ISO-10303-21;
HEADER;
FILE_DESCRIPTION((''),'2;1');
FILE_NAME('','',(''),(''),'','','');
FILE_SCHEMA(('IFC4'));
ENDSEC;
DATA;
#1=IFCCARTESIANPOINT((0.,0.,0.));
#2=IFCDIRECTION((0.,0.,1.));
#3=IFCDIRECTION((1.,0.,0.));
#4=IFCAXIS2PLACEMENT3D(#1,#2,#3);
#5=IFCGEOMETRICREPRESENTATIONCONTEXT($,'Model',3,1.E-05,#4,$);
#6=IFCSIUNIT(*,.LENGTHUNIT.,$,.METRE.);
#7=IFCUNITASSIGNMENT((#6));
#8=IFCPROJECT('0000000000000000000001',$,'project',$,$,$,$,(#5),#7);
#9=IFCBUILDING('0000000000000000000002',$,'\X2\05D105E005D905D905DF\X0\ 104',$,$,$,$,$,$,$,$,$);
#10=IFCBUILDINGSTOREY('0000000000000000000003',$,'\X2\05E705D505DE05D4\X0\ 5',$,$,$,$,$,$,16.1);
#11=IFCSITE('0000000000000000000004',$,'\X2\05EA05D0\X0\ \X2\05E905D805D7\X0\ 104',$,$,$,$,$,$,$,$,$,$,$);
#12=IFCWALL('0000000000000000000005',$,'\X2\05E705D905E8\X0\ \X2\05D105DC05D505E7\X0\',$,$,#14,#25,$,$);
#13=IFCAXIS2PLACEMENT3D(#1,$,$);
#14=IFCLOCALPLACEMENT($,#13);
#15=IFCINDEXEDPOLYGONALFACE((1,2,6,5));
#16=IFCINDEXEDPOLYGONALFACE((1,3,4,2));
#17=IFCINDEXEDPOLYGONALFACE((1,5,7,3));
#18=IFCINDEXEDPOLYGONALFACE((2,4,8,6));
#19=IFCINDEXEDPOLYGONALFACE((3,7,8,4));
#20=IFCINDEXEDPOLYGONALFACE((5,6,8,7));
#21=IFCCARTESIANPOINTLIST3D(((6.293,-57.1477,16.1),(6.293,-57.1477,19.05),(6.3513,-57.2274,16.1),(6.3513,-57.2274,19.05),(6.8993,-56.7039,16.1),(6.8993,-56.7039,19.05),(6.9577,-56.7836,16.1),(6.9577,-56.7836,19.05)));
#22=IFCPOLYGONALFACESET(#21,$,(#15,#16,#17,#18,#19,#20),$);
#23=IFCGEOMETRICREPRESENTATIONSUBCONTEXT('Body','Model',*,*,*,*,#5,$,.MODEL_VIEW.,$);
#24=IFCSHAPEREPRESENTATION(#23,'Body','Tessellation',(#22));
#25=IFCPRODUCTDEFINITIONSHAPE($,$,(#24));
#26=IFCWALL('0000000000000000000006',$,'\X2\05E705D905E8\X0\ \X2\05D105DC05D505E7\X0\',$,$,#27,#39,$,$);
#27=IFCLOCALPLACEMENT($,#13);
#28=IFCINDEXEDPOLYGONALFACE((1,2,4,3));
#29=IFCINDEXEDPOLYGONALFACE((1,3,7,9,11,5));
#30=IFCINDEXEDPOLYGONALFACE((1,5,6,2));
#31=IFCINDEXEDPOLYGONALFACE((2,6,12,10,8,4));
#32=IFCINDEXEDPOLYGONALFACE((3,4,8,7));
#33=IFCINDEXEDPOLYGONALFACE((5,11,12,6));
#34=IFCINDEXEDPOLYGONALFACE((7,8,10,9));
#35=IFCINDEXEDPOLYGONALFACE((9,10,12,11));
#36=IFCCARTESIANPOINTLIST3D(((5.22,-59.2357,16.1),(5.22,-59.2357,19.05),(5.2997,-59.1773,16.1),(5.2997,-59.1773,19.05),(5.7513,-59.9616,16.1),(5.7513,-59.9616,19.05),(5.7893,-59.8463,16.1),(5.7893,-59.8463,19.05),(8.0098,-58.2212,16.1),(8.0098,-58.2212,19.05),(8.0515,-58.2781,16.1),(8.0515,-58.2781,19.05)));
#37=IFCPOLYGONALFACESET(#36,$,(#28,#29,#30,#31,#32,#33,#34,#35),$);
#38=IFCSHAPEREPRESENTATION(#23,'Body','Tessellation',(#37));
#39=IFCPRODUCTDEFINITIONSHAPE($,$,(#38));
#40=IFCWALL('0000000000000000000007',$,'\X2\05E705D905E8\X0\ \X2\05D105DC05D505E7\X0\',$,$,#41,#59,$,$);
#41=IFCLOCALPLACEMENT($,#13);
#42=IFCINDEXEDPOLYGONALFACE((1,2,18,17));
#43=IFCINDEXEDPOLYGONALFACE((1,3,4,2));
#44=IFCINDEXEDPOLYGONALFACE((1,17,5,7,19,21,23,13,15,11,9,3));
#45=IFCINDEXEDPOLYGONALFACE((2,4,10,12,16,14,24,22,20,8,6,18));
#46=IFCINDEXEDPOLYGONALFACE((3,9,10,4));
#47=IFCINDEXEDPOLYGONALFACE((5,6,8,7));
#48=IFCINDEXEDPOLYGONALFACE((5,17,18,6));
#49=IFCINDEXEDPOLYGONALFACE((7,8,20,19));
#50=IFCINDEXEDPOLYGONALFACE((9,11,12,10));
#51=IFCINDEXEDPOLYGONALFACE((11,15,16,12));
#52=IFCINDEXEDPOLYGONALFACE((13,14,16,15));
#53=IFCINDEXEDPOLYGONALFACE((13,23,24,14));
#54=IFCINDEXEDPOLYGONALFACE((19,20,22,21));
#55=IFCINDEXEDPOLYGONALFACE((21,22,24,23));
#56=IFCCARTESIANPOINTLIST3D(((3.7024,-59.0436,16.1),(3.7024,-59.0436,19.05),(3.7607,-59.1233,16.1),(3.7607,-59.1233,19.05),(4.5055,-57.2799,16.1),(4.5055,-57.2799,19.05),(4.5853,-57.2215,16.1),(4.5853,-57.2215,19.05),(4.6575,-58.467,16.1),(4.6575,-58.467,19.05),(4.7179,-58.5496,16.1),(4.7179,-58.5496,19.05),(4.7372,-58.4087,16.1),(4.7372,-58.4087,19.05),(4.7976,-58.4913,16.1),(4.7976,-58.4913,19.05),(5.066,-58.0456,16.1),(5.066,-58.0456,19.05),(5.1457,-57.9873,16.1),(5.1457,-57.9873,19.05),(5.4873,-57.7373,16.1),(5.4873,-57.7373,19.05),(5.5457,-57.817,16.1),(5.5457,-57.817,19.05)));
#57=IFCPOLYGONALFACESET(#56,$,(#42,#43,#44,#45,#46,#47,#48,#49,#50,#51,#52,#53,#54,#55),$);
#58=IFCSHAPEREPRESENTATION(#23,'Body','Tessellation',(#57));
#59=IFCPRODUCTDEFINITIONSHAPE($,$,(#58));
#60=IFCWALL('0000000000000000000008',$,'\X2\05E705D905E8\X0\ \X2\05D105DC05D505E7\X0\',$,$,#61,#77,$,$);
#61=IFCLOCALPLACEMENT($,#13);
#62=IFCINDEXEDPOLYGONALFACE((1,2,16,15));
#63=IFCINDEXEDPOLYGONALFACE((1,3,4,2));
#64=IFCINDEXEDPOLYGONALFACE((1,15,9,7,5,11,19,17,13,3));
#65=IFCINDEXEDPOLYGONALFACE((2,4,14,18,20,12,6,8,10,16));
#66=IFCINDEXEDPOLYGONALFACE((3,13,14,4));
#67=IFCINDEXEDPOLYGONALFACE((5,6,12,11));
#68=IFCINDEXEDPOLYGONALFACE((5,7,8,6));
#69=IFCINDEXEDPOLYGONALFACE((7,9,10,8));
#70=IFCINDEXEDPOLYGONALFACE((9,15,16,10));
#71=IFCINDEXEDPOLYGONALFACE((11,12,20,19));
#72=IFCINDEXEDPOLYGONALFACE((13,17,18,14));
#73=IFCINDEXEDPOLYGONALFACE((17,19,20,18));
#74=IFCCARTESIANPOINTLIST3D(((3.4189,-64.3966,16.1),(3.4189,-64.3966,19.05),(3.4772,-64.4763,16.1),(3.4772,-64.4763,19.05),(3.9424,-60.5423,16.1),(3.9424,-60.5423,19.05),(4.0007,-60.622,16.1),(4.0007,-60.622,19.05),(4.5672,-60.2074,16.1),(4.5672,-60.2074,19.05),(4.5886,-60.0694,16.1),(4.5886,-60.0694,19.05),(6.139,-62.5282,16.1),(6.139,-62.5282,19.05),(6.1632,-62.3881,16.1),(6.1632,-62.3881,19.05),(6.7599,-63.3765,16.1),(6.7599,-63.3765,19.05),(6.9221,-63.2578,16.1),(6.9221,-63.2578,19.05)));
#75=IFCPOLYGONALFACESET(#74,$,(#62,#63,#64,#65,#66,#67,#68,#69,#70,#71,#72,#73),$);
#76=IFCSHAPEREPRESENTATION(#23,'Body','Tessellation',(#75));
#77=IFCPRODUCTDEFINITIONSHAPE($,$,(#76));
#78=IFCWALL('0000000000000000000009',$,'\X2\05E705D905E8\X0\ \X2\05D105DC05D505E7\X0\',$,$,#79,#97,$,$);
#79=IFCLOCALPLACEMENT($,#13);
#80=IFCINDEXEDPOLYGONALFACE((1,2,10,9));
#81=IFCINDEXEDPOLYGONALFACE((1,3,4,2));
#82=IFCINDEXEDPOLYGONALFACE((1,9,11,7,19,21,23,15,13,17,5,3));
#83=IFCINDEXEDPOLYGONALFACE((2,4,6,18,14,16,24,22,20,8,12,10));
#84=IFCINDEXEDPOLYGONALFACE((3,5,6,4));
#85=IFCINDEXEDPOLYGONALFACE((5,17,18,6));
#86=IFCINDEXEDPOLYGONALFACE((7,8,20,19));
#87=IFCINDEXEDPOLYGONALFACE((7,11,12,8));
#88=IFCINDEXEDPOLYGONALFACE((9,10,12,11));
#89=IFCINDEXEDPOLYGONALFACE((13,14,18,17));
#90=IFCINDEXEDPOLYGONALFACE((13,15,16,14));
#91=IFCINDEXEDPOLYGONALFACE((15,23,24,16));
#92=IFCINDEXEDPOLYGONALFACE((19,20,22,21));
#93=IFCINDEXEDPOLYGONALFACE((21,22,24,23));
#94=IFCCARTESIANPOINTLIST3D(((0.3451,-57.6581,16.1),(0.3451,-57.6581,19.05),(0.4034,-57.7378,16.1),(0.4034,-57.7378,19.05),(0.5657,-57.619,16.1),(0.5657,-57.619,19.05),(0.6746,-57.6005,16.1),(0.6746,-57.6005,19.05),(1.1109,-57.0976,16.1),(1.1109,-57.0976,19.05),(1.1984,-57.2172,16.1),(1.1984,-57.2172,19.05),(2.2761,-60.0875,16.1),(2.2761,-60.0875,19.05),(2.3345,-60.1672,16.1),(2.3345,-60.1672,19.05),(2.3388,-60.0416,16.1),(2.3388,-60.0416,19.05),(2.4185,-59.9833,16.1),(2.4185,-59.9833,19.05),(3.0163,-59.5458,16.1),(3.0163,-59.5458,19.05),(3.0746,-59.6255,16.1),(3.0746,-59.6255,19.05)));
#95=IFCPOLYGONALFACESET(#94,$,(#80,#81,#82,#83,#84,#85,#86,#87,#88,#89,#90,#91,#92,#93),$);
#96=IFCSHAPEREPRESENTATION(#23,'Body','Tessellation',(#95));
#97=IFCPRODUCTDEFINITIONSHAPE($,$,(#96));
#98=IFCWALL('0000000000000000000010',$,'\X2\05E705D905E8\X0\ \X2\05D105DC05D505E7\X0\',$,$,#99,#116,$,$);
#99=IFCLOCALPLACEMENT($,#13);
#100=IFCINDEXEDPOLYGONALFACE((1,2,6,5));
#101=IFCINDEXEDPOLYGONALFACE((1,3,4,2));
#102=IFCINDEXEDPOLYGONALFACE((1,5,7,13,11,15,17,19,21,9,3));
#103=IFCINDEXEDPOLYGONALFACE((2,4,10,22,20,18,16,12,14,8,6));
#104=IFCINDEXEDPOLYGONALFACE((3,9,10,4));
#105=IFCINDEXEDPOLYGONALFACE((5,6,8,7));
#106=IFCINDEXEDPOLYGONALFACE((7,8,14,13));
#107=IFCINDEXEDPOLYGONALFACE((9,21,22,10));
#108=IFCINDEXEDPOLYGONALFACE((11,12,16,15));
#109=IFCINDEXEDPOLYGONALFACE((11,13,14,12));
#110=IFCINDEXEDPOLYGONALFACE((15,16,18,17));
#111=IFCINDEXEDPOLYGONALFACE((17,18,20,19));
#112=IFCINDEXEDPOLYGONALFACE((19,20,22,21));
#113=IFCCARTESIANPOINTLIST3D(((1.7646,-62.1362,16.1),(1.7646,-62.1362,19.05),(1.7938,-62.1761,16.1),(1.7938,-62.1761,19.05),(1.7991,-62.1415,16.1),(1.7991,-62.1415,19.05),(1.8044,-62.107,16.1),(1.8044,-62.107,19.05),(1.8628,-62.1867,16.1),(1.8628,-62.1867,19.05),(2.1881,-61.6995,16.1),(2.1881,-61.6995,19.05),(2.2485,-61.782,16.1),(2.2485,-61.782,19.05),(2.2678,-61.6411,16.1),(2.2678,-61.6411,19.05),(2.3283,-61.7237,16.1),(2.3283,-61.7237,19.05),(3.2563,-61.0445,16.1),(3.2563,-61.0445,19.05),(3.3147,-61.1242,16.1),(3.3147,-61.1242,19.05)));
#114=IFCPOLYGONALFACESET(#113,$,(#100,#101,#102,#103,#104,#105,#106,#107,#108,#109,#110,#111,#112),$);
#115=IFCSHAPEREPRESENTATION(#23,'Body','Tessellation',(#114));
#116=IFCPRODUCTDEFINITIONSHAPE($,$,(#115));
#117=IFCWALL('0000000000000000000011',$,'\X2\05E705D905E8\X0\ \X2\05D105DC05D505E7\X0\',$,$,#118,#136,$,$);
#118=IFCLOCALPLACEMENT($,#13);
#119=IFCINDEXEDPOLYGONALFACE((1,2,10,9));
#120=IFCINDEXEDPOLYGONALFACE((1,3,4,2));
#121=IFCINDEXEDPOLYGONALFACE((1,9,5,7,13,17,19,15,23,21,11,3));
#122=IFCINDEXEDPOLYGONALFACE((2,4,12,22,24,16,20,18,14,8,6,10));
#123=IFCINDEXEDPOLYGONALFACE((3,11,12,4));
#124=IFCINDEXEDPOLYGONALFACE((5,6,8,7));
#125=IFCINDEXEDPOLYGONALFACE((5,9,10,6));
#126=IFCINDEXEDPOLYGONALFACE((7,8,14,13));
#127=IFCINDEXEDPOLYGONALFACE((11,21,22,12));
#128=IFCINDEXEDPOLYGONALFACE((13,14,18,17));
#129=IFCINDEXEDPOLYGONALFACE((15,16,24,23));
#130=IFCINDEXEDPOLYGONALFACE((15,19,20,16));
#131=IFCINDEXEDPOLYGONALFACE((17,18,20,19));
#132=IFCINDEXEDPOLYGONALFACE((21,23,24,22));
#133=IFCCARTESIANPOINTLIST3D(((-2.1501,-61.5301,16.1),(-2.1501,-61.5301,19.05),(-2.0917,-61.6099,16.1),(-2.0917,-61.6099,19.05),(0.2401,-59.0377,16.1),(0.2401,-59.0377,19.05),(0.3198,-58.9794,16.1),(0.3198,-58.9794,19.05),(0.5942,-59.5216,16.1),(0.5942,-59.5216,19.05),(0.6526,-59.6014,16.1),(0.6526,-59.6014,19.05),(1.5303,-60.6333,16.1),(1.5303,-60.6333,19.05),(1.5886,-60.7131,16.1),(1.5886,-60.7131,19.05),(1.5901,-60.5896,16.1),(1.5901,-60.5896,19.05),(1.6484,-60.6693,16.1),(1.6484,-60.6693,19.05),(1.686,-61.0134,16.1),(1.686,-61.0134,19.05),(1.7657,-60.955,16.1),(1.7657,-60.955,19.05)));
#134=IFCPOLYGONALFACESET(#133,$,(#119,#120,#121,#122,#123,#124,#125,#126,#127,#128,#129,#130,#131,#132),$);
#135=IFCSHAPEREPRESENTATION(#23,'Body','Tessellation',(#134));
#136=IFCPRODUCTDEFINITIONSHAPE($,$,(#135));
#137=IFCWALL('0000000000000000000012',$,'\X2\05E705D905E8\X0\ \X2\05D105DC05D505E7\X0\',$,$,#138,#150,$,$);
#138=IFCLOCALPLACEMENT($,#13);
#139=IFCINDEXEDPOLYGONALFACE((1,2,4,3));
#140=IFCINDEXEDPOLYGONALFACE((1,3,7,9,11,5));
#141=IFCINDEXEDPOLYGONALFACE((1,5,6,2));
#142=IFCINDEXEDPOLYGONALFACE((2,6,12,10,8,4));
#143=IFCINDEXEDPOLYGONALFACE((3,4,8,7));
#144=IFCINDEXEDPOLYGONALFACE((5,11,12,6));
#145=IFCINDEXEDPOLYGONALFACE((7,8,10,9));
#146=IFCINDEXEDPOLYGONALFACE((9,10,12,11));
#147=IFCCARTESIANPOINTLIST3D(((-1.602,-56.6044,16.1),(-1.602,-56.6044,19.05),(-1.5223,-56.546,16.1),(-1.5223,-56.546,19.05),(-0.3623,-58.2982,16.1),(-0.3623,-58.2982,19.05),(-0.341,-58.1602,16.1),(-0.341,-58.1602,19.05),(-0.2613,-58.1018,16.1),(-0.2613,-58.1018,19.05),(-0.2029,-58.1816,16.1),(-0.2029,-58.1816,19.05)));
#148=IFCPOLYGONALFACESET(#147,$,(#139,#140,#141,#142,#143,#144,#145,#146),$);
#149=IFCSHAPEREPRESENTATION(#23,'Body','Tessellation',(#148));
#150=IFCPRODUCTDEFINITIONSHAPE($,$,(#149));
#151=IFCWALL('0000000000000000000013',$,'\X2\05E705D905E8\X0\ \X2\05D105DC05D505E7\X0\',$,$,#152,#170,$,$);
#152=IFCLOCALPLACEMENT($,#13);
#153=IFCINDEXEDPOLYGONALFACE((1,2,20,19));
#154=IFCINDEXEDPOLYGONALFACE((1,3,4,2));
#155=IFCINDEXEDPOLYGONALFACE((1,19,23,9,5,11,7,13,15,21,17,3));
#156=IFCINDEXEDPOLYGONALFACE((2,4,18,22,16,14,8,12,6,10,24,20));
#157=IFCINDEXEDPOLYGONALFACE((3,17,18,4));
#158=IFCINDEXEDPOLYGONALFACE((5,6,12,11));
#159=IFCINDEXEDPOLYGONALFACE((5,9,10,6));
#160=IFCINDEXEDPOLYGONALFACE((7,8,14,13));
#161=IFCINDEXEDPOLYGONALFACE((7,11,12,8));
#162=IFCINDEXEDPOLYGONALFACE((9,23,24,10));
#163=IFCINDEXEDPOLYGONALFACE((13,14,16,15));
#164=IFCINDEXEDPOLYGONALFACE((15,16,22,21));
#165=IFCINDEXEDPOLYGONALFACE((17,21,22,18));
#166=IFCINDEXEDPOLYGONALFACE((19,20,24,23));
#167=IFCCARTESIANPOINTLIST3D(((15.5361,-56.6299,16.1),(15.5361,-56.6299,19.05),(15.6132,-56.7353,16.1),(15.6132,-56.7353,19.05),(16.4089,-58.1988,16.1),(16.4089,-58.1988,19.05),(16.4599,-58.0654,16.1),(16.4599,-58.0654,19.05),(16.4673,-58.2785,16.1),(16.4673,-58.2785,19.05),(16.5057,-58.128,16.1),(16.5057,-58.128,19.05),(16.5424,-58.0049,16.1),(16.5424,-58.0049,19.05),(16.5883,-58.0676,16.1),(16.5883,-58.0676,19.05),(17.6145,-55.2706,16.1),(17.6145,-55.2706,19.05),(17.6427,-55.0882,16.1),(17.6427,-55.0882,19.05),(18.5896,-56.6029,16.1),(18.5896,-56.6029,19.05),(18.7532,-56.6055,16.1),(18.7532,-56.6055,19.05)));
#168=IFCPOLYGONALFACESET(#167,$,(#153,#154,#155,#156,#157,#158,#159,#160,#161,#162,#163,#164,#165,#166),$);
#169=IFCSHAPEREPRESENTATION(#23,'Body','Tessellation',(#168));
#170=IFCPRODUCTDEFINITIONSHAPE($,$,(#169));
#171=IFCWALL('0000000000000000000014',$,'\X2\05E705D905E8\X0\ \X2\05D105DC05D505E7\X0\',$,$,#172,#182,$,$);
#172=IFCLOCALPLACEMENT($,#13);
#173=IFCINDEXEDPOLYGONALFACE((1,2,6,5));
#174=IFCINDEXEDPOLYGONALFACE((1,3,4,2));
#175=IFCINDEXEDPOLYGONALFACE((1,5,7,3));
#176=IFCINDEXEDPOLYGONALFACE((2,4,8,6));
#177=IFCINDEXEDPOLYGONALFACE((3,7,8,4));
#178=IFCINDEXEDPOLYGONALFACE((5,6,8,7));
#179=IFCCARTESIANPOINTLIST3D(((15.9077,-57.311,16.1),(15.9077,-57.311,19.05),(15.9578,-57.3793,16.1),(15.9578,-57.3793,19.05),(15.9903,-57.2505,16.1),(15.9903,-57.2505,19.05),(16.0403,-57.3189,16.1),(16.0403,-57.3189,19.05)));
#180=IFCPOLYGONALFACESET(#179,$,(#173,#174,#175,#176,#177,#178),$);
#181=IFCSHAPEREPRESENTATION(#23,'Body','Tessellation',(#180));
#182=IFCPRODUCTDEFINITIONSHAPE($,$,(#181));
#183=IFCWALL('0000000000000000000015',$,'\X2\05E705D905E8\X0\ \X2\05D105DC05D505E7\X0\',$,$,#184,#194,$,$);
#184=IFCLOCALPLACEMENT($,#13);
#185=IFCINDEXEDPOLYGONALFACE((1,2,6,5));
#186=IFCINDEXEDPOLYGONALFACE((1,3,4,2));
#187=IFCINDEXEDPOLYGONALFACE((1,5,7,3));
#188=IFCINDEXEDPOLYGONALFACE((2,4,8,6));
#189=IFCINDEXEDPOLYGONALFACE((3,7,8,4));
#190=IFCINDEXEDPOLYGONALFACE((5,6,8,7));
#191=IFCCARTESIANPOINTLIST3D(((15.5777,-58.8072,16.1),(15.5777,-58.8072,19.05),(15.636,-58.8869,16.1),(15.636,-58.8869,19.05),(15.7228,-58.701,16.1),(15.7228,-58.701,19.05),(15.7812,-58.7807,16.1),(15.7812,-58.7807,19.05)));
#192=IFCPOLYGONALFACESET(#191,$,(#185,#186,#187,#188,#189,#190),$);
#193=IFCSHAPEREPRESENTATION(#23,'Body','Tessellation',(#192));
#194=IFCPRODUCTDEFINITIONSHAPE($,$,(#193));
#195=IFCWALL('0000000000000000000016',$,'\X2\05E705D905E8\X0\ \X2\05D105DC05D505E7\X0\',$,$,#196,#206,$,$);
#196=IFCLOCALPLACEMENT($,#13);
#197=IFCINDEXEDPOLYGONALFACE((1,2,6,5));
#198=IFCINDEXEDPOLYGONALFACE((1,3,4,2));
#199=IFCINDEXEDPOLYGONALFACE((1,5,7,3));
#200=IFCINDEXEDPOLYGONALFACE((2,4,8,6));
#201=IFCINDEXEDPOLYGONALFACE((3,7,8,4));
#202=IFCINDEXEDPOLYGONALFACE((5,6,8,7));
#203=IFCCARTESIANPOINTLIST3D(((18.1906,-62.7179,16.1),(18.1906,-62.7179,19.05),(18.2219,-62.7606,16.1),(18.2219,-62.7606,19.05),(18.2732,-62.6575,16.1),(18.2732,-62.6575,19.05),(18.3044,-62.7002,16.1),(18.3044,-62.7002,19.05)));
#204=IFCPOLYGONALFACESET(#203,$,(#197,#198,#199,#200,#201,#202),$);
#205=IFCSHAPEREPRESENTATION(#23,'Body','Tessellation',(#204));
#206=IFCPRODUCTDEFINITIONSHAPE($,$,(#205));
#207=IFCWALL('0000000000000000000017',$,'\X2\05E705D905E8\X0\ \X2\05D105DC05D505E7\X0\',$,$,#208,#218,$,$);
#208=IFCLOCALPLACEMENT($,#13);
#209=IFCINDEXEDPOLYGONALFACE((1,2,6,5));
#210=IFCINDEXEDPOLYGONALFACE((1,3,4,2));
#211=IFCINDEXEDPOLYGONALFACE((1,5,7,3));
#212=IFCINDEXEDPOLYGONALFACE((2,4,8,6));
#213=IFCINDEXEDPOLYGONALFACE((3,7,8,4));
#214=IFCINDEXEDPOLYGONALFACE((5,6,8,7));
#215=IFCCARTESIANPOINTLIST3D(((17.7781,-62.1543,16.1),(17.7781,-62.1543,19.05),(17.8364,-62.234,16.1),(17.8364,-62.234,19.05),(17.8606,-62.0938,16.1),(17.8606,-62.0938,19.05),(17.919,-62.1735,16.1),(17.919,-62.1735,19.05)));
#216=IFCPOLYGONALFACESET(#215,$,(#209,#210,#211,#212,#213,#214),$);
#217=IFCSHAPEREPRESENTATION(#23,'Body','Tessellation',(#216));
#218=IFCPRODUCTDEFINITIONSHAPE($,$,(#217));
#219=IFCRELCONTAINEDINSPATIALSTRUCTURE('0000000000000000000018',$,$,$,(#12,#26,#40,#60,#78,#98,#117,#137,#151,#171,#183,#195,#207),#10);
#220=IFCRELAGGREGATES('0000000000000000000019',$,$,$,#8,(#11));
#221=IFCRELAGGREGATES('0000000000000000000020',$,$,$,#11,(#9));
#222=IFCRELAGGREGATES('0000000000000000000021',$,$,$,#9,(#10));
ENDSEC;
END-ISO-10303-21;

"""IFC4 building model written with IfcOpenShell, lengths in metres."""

from ifc_helpers import new_model, si_unit, frame, origin_with_axes, context, subcontext, project, spatial, polyline, outline, extrude, element, save


model = new_model("IFC4")

# Units and contexts
model_context = context("Model", 3, precision=1e-05, world=origin_with_axes())
body_context = subcontext(model_context, "Body", "Model", "MODEL_VIEW")
ifc_project = project(units=[si_unit("LENGTHUNIT", "METRE")], contexts=[model_context])

# Site, building, storey
site = spatial("IfcSite", under=ifc_project, Name="תא שטח 104")
building = spatial("IfcBuilding", under=site, Name="בניין 104")
storey = spatial("IfcBuildingStorey", under=building, Name="קומה 5", Elevation=16.1)

# Walls
element("IfcWall", 1, inside=storey, Name="קיר בלוק", context=body_context, shape_type="SweptSolid", body=[
    extrude(outline(polyline([(6.3513, -57.2274), (6.9577, -56.7836), (6.8993, -56.7039), (6.293, -57.1477), (6.3513, -57.2274)])), frame((0.0, 0.0, 16.1)), (0.0, 0.0, 1.0), 2.95),
])
element("IfcWall", 2, inside=storey, Name="קיר בלוק", context=body_context, shape_type="SweptSolid", body=[
    extrude(outline(polyline([(5.22, -59.2357), (5.7513, -59.9616), (8.0515, -58.2781), (8.0098, -58.2212), (5.7893, -59.8463), (5.2997, -59.1773), (5.22, -59.2357)])), frame((0.0, 0.0, 16.1)), (0.0, 0.0, 1.0), 2.95),
])
element("IfcWall", 3, inside=storey, Name="קיר בלוק", context=body_context, shape_type="SweptSolid", body=[
    extrude(outline(polyline([(3.7024, -59.0436), (3.7607, -59.1233), (4.6575, -58.467), (4.7179, -58.5496), (4.7976, -58.4913), (4.7372, -58.4087), (5.5457, -57.817), (5.4873, -57.7373), (5.1457, -57.9873), (4.5853, -57.2215), (4.5055, -57.2799), (5.066, -58.0456), (3.7024, -59.0436)])), frame((0.0, 0.0, 16.1)), (0.0, 0.0, 1.0), 2.95),
])
element("IfcWall", 4, inside=storey, Name="קיר בלוק", context=body_context, shape_type="SweptSolid", body=[
    extrude(outline(polyline([(4.0007, -60.622), (4.5672, -60.2074), (6.1632, -62.3881), (3.4189, -64.3966), (3.4772, -64.4763), (6.139, -62.5282), (6.7599, -63.3765), (6.9221, -63.2578), (4.5886, -60.0694), (3.9424, -60.5423), (4.0007, -60.622)])), frame((0.0, 0.0, 16.1)), (0.0, 0.0, 1.0), 2.95),
])
element("IfcWall", 5, inside=storey, Name="קיר בלוק", context=body_context, shape_type="SweptSolid", body=[
    extrude(outline(polyline([(1.1109, -57.0976), (0.3451, -57.6581), (0.4034, -57.7378), (0.5657, -57.619), (2.3388, -60.0416), (2.2761, -60.0875), (2.3345, -60.1672), (3.0746, -59.6255), (3.0163, -59.5458), (2.4185, -59.9833), (0.6746, -57.6005), (1.1984, -57.2172), (1.1109, -57.0976)])), frame((0.0, 0.0, 16.1)), (0.0, 0.0, 1.0), 2.95),
])
element("IfcWall", 6, inside=storey, Name="קיר בלוק", context=body_context, shape_type="SweptSolid", body=[
    extrude(outline(polyline([(2.2485, -61.782), (1.8044, -62.107), (1.7991, -62.1415), (1.7646, -62.1362), (1.7938, -62.1761), (1.8628, -62.1867), (3.3147, -61.1242), (3.2563, -61.0445), (2.3283, -61.7237), (2.2678, -61.6411), (2.1881, -61.6995), (2.2485, -61.782)])), frame((0.0, 0.0, 16.1)), (0.0, 0.0, 1.0), 2.95),
])
element("IfcWall", 7, inside=storey, Name="קיר בלוק", context=body_context, shape_type="SweptSolid", body=[
    extrude(outline(polyline([(-2.1501, -61.5301), (-2.0917, -61.6099), (0.6526, -59.6014), (1.686, -61.0134), (1.7657, -60.955), (1.5886, -60.7131), (1.6484, -60.6693), (1.5901, -60.5896), (1.5303, -60.6333), (0.3198, -58.9794), (0.2401, -59.0377), (0.5942, -59.5216), (-2.1501, -61.5301)])), frame((0.0, 0.0, 16.1)), (0.0, 0.0, 1.0), 2.95),
])
element("IfcWall", 8, inside=storey, Name="קיר בלוק", context=body_context, shape_type="SweptSolid", body=[
    extrude(outline(polyline([(-1.602, -56.6044), (-0.3623, -58.2982), (-0.2029, -58.1816), (-0.2613, -58.1018), (-0.341, -58.1602), (-1.5223, -56.546), (-1.602, -56.6044)])), frame((0.0, 0.0, 16.1)), (0.0, 0.0, 1.0), 2.95),
])
element("IfcWall", 9, inside=storey, Name="קיר בלוק", context=body_context, shape_type="SweptSolid", body=[
    extrude(outline(polyline([(15.6132, -56.7353), (17.6145, -55.2706), (18.5896, -56.6029), (16.5883, -58.0676), (16.5424, -58.0049), (16.4599, -58.0654), (16.5057, -58.128), (16.4089, -58.1988), (16.4673, -58.2785), (18.7532, -56.6055), (17.6427, -55.0882), (15.5361, -56.6299), (15.6132, -56.7353)])), frame((0.0, 0.0, 16.1)), (0.0, 0.0, 1.0), 2.95),
])
element("IfcWall", 10, inside=storey, Name="קיר בלוק", context=body_context, shape_type="SweptSolid", body=[
    extrude(outline(polyline([(15.9077, -57.311), (15.9578, -57.3793), (16.0403, -57.3189), (15.9903, -57.2505), (15.9077, -57.311)])), frame((0.0, 0.0, 16.1)), (0.0, 0.0, 1.0), 2.95),
])
element("IfcWall", 11, inside=storey, Name="קיר בלוק", context=body_context, shape_type="SweptSolid", body=[
    extrude(outline(polyline([(15.7812, -58.7807), (15.7228, -58.701), (15.5777, -58.8072), (15.636, -58.8869), (15.7812, -58.7807)])), frame((0.0, 0.0, 16.1)), (0.0, 0.0, 1.0), 2.95),
])
element("IfcWall", 12, inside=storey, Name="קיר בלוק", context=body_context, shape_type="SweptSolid", body=[
    extrude(outline(polyline([(18.3044, -62.7002), (18.2732, -62.6575), (18.1906, -62.7179), (18.2219, -62.7606), (18.3044, -62.7002)])), frame((0.0, 0.0, 16.1)), (0.0, 0.0, 1.0), 2.95),
])
element("IfcWall", 13, inside=storey, Name="קיר בלוק", context=body_context, shape_type="SweptSolid", body=[
    extrude(outline(polyline([(17.919, -62.1735), (17.8606, -62.0938), (17.7781, -62.1543), (17.8364, -62.234), (17.919, -62.1735)])), frame((0.0, 0.0, 16.1)), (0.0, 0.0, 1.0), 2.95),
])

save(model, "model.ifc")
